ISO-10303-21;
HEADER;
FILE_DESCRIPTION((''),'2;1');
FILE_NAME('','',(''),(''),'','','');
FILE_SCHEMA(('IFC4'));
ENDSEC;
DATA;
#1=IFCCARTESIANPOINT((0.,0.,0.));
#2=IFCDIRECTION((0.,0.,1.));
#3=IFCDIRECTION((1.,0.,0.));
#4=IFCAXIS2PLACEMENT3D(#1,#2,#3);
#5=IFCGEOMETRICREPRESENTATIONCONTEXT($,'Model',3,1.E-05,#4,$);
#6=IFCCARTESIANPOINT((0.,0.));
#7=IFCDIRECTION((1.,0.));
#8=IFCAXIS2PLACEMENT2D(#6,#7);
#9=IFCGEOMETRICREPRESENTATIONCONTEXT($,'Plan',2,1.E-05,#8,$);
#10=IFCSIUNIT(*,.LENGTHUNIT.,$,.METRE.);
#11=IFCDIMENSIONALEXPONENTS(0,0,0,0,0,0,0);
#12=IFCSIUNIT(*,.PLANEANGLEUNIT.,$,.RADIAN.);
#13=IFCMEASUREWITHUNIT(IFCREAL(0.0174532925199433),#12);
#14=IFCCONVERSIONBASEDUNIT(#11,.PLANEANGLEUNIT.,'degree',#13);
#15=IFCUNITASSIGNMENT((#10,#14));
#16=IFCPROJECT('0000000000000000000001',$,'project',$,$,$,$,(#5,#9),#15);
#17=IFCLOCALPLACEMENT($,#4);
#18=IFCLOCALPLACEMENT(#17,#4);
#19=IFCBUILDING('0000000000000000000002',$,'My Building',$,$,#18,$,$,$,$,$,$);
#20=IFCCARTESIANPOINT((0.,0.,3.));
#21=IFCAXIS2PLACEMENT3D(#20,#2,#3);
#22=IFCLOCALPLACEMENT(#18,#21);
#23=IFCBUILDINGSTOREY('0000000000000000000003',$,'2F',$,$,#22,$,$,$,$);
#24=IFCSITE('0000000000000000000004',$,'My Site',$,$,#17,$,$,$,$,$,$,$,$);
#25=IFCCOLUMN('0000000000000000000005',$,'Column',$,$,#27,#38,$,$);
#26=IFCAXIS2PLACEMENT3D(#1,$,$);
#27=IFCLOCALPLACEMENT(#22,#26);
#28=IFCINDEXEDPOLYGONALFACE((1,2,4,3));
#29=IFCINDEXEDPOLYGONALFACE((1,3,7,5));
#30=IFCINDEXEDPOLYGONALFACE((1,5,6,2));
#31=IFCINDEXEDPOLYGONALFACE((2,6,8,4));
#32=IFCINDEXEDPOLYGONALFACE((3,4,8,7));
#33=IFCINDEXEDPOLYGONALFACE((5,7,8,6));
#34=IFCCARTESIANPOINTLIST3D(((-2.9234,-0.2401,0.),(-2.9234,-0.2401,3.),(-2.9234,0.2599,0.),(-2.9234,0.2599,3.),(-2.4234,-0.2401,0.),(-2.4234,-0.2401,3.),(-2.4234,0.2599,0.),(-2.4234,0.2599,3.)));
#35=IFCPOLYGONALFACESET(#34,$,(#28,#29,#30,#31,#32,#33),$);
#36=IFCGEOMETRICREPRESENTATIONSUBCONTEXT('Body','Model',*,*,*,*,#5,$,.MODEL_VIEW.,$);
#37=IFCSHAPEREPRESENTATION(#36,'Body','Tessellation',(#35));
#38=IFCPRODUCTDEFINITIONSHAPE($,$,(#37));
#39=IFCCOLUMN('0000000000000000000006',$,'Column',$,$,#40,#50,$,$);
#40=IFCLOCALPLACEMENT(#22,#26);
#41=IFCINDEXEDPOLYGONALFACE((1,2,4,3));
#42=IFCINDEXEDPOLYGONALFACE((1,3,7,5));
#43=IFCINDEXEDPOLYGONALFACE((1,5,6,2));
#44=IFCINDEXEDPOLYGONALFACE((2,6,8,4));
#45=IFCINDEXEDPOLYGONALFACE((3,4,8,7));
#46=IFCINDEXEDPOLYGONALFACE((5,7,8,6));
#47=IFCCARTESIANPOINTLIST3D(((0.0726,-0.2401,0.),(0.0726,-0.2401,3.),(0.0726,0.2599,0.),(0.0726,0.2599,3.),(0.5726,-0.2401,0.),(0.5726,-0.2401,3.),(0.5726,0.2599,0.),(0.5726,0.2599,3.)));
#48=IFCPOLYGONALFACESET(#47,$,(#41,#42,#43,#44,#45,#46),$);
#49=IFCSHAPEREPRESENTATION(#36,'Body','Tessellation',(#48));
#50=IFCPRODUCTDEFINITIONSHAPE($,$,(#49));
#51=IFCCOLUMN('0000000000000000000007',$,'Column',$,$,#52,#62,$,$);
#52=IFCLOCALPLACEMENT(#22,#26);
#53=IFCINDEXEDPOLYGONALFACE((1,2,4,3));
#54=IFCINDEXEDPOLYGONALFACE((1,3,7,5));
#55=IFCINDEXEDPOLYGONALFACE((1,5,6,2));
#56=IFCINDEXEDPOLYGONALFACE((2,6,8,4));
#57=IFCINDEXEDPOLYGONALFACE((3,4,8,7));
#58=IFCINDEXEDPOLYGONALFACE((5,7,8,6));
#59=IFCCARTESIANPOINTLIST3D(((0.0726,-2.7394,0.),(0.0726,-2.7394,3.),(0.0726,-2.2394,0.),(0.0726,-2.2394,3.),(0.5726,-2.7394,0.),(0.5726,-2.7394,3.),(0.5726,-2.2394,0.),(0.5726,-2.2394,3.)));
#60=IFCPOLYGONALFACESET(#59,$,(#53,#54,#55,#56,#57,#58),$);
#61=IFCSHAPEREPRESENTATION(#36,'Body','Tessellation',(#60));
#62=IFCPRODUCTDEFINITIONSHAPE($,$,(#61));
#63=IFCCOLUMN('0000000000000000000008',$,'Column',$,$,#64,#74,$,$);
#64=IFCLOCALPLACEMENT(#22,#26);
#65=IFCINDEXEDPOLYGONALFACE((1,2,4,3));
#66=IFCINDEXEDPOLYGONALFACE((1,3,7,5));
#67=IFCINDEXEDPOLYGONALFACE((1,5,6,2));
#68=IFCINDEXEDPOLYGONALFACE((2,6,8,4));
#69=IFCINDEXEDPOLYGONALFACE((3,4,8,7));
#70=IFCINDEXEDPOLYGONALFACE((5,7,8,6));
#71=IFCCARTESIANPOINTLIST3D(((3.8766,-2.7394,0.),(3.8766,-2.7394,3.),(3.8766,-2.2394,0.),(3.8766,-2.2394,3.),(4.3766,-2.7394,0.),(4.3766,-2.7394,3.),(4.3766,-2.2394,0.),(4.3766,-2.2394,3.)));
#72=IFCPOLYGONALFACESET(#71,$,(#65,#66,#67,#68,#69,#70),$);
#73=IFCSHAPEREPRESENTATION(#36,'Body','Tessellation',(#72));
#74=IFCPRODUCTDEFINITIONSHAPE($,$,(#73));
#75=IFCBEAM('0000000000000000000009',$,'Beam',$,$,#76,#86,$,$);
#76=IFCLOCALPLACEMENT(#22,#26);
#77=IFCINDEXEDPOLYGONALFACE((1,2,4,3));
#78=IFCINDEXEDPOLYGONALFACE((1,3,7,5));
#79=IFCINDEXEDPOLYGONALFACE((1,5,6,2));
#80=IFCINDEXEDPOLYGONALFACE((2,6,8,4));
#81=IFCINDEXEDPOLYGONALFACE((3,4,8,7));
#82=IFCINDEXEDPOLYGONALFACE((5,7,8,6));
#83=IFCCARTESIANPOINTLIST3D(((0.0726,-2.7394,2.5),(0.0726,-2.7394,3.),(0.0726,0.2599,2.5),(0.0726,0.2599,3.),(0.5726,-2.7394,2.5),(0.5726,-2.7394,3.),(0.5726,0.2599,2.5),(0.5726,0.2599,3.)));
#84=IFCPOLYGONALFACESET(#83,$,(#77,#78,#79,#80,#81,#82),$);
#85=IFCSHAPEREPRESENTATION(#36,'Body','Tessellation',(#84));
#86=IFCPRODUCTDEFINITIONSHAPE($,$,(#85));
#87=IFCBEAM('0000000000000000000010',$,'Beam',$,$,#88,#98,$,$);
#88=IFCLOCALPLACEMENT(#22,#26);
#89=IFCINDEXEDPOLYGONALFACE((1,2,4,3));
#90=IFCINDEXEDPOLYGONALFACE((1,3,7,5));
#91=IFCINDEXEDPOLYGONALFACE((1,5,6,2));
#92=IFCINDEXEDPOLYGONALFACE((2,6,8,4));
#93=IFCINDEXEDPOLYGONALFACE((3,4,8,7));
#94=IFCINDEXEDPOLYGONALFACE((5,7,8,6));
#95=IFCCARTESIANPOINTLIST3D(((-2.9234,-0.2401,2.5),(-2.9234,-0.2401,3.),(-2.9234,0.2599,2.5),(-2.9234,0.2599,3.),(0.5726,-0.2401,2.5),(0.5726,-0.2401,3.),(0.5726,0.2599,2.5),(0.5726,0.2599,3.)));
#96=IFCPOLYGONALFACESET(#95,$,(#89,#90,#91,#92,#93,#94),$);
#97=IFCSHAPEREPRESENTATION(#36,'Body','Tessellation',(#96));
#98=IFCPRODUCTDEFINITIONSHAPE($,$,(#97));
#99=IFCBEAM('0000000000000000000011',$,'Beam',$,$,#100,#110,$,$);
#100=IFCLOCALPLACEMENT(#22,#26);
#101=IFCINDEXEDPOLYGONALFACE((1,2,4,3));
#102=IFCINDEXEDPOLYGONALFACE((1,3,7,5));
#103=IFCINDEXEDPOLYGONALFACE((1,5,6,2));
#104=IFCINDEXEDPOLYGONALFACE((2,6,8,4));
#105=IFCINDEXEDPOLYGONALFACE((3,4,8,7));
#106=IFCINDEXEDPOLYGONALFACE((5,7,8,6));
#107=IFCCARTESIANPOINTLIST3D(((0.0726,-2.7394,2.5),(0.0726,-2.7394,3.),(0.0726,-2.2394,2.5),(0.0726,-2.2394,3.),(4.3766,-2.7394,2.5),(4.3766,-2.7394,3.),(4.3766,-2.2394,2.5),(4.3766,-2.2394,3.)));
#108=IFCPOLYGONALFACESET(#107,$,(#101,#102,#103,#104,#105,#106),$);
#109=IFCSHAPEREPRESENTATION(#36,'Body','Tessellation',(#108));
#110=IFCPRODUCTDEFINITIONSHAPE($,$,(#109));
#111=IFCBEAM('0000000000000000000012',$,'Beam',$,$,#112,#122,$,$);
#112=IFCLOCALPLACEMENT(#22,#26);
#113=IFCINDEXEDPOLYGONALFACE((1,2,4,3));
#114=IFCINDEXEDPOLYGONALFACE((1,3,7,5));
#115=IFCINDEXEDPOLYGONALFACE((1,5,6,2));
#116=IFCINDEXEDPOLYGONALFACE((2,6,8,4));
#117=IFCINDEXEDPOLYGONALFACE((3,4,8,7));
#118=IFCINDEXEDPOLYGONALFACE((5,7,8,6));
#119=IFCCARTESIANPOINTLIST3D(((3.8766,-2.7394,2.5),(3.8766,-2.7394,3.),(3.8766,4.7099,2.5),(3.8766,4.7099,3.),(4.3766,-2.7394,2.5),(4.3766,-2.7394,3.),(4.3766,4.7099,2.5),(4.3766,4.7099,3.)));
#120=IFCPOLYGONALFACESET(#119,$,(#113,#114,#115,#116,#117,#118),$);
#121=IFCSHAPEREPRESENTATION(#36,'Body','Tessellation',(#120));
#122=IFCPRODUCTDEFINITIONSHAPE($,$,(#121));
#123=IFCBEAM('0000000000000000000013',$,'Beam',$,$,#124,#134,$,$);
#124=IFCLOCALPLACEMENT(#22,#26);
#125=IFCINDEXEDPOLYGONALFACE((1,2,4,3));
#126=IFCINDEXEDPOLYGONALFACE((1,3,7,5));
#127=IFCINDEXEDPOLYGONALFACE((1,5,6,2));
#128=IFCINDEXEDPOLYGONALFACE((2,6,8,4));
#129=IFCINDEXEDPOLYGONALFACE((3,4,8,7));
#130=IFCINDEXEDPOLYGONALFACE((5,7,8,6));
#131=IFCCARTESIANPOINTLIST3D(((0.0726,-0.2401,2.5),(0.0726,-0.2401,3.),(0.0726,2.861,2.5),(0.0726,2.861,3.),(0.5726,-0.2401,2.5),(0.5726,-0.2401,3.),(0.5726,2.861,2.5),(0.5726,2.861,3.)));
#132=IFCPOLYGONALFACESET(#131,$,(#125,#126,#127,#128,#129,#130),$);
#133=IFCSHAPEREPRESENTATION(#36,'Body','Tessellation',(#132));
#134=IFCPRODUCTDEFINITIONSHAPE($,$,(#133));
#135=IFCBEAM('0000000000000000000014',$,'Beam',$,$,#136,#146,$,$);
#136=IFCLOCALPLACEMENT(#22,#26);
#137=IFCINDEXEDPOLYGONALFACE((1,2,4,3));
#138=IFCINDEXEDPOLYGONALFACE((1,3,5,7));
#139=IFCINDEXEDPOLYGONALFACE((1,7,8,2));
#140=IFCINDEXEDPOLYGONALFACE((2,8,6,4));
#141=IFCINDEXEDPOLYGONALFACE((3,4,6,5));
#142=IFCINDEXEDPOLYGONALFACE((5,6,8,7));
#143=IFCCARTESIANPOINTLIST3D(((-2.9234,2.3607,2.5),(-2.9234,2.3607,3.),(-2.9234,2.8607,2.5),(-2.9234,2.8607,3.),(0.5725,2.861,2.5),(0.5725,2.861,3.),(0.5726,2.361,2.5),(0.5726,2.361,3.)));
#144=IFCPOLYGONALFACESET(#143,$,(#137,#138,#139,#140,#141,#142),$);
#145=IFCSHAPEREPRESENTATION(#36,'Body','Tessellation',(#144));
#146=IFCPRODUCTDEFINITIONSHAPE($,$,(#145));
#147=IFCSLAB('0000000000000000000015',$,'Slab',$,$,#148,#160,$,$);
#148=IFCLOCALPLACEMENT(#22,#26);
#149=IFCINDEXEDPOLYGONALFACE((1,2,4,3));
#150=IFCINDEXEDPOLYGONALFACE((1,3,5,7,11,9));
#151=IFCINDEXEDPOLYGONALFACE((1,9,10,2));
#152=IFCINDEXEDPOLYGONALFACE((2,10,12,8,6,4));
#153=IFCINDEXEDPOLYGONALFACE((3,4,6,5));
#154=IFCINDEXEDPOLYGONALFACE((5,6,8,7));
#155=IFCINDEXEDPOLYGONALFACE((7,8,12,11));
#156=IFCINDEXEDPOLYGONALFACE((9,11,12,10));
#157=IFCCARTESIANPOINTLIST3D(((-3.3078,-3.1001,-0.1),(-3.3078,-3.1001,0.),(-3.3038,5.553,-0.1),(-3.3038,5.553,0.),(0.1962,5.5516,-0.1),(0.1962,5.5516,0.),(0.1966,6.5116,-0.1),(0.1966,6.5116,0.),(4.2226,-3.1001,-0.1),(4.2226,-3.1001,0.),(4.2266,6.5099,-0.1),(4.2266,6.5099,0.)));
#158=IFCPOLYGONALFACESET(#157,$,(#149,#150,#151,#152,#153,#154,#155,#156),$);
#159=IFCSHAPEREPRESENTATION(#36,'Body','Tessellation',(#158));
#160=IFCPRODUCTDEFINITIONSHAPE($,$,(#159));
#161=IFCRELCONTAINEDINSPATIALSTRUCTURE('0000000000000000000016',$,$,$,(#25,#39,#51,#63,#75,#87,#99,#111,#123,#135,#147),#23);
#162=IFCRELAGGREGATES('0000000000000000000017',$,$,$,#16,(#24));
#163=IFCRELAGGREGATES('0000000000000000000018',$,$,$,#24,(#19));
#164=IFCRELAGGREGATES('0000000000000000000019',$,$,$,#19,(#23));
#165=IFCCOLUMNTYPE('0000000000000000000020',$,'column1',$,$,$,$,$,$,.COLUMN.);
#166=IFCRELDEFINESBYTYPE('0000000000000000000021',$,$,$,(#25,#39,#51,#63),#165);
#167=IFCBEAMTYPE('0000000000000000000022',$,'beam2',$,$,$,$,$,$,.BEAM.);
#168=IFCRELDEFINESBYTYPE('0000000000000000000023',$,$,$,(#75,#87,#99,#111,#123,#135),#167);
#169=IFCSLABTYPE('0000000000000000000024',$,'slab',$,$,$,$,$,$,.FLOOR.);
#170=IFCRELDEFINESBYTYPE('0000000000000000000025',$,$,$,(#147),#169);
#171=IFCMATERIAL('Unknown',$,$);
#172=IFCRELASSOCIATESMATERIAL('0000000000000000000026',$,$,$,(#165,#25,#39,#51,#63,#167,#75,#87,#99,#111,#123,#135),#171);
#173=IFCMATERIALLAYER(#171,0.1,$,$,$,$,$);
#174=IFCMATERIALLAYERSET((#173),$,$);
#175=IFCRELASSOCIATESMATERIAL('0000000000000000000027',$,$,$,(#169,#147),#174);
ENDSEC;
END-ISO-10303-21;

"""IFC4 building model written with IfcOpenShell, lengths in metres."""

from ifc_helpers import new_model, entity, si_unit, converted_unit, frame, origin_with_axes, origin_2d_with_axis, place, context, subcontext, project, spatial, indexed_curve, rectangle, outline, extrude, material, layer, layer_set, layer_usage, material_profile, profile_set, profile_usage, type_object, element, save


model = new_model("IFC4")

# Units and contexts
model_context = context("Model", 3, precision=1e-05, world=origin_with_axes())
plan_context = context("Plan", 2, precision=1e-05, world=origin_2d_with_axis())
body_context_1 = subcontext(model_context, "Body", "Model", "MODEL_VIEW")
ifc_project = project(units=[si_unit("LENGTHUNIT", "METRE"), converted_unit("PLANEANGLEUNIT", "degree", entity("IfcReal", 0.0174532925199433), si_unit("PLANEANGLEUNIT", "RADIAN"), dimensions=[0, 0, 0, 0, 0, 0, 0])], contexts=[model_context, plan_context])

# Site, building, storey
site_placement = place(None, origin_with_axes())
site = spatial("IfcSite", under=ifc_project, at=site_placement, Name="My Site")
building_placement = place(site_placement, origin_with_axes())
building = spatial("IfcBuilding", under=site, at=building_placement, Name="My Building")
storey_placement = place(building_placement, frame((0.0, 0.0, 3.0), z_axis=(0.0, 0.0, 1.0), x_axis=(1.0, 0.0, 0.0)))
storey = spatial("IfcBuildingStorey", under=building, at=storey_placement, Name="2F")

# Columns
ifc_material = material(Name="Unknown")
ifc_material_profile_1 = material_profile(ifc_material, rectangle(XDim=0.5, YDim=0.5))
ifc_profile_set_1 = profile_set([ifc_material_profile_1])
ifc_profile_usage_1 = profile_usage(ifc_profile_set_1, cardinal=7)
column_type = type_object("IfcColumnType", Name="column1", PredefinedType="COLUMN", material=ifc_profile_set_1)
column_1_placement = place(storey_placement, frame((-2.4234, 0.2599, 0.0), z_axis=(0.0, 0.0, 1.0), x_axis=(1.0, 0.0, 0.0)))
element("IfcColumn", 1, at=column_1_placement, inside=storey, type_object=column_type, material=ifc_profile_usage_1, Name="Column", context=body_context_1, shape_type="SweptSolid", body=[
    extrude(rectangle(XDim=0.5, YDim=0.5), frame((-0.25, -0.25, 0.0), z_axis=(0.0, 0.0, 1.0), x_axis=(1.0, 0.0, 0.0)), (0.0, 0.0, 1.0), 3.0),
])
ifc_profile_usage_2 = profile_usage(ifc_profile_set_1, cardinal=7)
column_2_placement = place(storey_placement, frame((0.5726, 0.2599, 0.0), z_axis=(0.0, 0.0, 1.0), x_axis=(1.0, 0.0, 0.0)))
element("IfcColumn", 2, at=column_2_placement, inside=storey, type_object=column_type, material=ifc_profile_usage_2, Name="Column", context=body_context_1, shape_type="SweptSolid", body=[
    extrude(rectangle(XDim=0.5, YDim=0.5), frame((-0.25, -0.25, 0.0), z_axis=(0.0, 0.0, 1.0), x_axis=(1.0, 0.0, 0.0)), (0.0, 0.0, 1.0), 3.0),
])
ifc_profile_usage_3 = profile_usage(ifc_profile_set_1, cardinal=7)
column_3_placement = place(storey_placement, frame((0.5726, -2.2394, 0.0), z_axis=(0.0, 0.0, 1.0), x_axis=(1.0, 0.0, 0.0)))
element("IfcColumn", 3, at=column_3_placement, inside=storey, type_object=column_type, material=ifc_profile_usage_3, Name="Column", context=body_context_1, shape_type="SweptSolid", body=[
    extrude(rectangle(XDim=0.5, YDim=0.5), frame((-0.25, -0.25, 0.0), z_axis=(0.0, 0.0, 1.0), x_axis=(1.0, 0.0, 0.0)), (0.0, 0.0, 1.0), 3.0),
])
ifc_profile_usage_4 = profile_usage(ifc_profile_set_1, cardinal=7)
column_4_placement = place(storey_placement, frame((4.3766, -2.2394, 0.0), z_axis=(0.0, 0.0, 1.0), x_axis=(1.0, 0.0, 0.0)))
element("IfcColumn", 4, at=column_4_placement, inside=storey, type_object=column_type, material=ifc_profile_usage_4, Name="Column", context=body_context_1, shape_type="SweptSolid", body=[
    extrude(rectangle(XDim=0.5, YDim=0.5), frame((-0.25, -0.25, 0.0), z_axis=(0.0, 0.0, 1.0), x_axis=(1.0, 0.0, 0.0)), (0.0, 0.0, 1.0), 3.0),
])

# Beams
ifc_material_profile_2 = material_profile(ifc_material, rectangle(XDim=0.5, YDim=0.5))
ifc_profile_set_2 = profile_set([ifc_material_profile_2])
ifc_profile_usage_5 = profile_usage(ifc_profile_set_2, cardinal=7)
beam_type = type_object("IfcBeamType", Name="beam2", PredefinedType="BEAM", material=ifc_profile_set_2)
beam_1_placement = place(storey_placement, frame((0.5726, 0.2599, 3.0), z_axis=(0.0, -1.0, 0.0), x_axis=(1.0, 0.0, 0.0)))
element("IfcBeam", 5, at=beam_1_placement, inside=storey, type_object=beam_type, material=ifc_profile_usage_5, Name="Beam", context=body_context_1, shape_type="SweptSolid", body=[
    extrude(rectangle(XDim=0.5, YDim=0.5), frame((-0.25, -0.25, 0.0), z_axis=(0.0, 0.0, 1.0), x_axis=(1.0, 0.0, 0.0)), (0.0, 0.0, 1.0), 2.9993),
])
ifc_profile_usage_6 = profile_usage(ifc_profile_set_2, cardinal=7)
beam_2_placement = place(storey_placement, frame((-2.9234, 0.2599, 3.0), z_axis=(1.0, -0.000001, 0.000001), x_axis=(0.000001, 1.0, 0.0)))
element("IfcBeam", 6, at=beam_2_placement, inside=storey, type_object=beam_type, material=ifc_profile_usage_6, Name="Beam", context=body_context_1, shape_type="SweptSolid", body=[
    extrude(rectangle(XDim=0.5, YDim=0.5), frame((-0.25, -0.25, 0.0), z_axis=(0.0, 0.0, 1.0), x_axis=(1.0, 0.0, 0.0)), (0.0, 0.0, 1.0), 3.496),
])
ifc_profile_usage_7 = profile_usage(ifc_profile_set_2, cardinal=7)
beam_3_placement = place(storey_placement, frame((0.0726, -2.2394, 3.0), z_axis=(1.0, 0.0, 0.0), x_axis=(0.0, 1.0, 0.0)))
element("IfcBeam", 7, at=beam_3_placement, inside=storey, type_object=beam_type, material=ifc_profile_usage_7, Name="Beam", context=body_context_1, shape_type="SweptSolid", body=[
    extrude(rectangle(XDim=0.5, YDim=0.5), frame((-0.25, -0.25, 0.0), z_axis=(0.0, 0.0, 1.0), x_axis=(1.0, 0.0, 0.0)), (0.0, 0.0, 1.0), 4.304),
])
ifc_profile_usage_8 = profile_usage(ifc_profile_set_2, cardinal=7)
beam_4_placement = place(storey_placement, frame((3.8766, -2.7394, 3.0), z_axis=(0.0, 1.0, 0.0), x_axis=(-1.0, 0.0, 0.0)))
element("IfcBeam", 8, at=beam_4_placement, inside=storey, type_object=beam_type, material=ifc_profile_usage_8, Name="Beam", context=body_context_1, shape_type="SweptSolid", body=[
    extrude(rectangle(XDim=0.5, YDim=0.5), frame((-0.25, -0.25, 0.0), z_axis=(0.0, 0.0, 1.0), x_axis=(1.0, 0.0, 0.0)), (0.0, 0.0, 1.0), 7.4493),
])
ifc_profile_usage_9 = profile_usage(ifc_profile_set_2, cardinal=7)
beam_5_placement = place(storey_placement, frame((0.0726, -0.2401, 3.0), z_axis=(0.0, 1.0, 0.0), x_axis=(-1.0, 0.0, 0.0)))
element("IfcBeam", 9, at=beam_5_placement, inside=storey, type_object=beam_type, material=ifc_profile_usage_9, Name="Beam", context=body_context_1, shape_type="SweptSolid", body=[
    extrude(rectangle(XDim=0.5, YDim=0.5), frame((-0.25, -0.25, 0.0), z_axis=(0.0, 0.0, 1.0), x_axis=(1.0, 0.0, 0.0)), (0.0, 0.0, 1.0), 3.1011),
])
ifc_profile_usage_10 = profile_usage(ifc_profile_set_2, cardinal=7)
beam_6_placement = place(storey_placement, frame((0.5726, 2.361, 3.0), z_axis=(-1.0, -0.000105, 0.0), x_axis=(0.000105, -1.0, 0.0)))
element("IfcBeam", 10, at=beam_6_placement, inside=storey, type_object=beam_type, material=ifc_profile_usage_10, Name="Beam", context=body_context_1, shape_type="SweptSolid", body=[
    extrude(rectangle(XDim=0.5, YDim=0.5), frame((-0.25, -0.25, 0.0), z_axis=(0.0, 0.0, 1.0), x_axis=(1.0, 0.0, 0.0)), (0.0, 0.0, 1.0), 3.496),
])

# Slab
ifc_layer_1 = layer(ifc_material, 0.1)
ifc_layer_set_1 = layer_set([ifc_layer_1])
ifc_layer_usage_1 = layer_usage(ifc_layer_set_1, "AXIS3", "POSITIVE", -0.1)
slab_type = type_object("IfcSlabType", Name="slab", PredefinedType="FLOOR", material=ifc_layer_set_1)
slab_placement = place(storey_placement, frame((-3.3078, -3.1001, 0.0), z_axis=(0.0, 0.0, 1.0), x_axis=(1.0, 0.0, 0.0)))
element("IfcSlab", 11, at=slab_placement, inside=storey, type_object=slab_type, material=ifc_layer_usage_1, Name="Slab", context=body_context_1, shape_type="SweptSolid", body=[
    extrude(outline(indexed_curve([(0.0, 0.0), (7.5304, 0.0), (7.5344, 9.61), (3.5044, 9.6117), (3.504, 8.6517), (0.004, 8.6531), (0.0, 0.0)])), frame((0.0, 0.0, -0.1), z_axis=(0.0, 0.0, 1.0), x_axis=(1.0, 0.0, 0.0)), (0.0, 0.0, 1.0), 0.1),
])

save(model, "model.ifc")
